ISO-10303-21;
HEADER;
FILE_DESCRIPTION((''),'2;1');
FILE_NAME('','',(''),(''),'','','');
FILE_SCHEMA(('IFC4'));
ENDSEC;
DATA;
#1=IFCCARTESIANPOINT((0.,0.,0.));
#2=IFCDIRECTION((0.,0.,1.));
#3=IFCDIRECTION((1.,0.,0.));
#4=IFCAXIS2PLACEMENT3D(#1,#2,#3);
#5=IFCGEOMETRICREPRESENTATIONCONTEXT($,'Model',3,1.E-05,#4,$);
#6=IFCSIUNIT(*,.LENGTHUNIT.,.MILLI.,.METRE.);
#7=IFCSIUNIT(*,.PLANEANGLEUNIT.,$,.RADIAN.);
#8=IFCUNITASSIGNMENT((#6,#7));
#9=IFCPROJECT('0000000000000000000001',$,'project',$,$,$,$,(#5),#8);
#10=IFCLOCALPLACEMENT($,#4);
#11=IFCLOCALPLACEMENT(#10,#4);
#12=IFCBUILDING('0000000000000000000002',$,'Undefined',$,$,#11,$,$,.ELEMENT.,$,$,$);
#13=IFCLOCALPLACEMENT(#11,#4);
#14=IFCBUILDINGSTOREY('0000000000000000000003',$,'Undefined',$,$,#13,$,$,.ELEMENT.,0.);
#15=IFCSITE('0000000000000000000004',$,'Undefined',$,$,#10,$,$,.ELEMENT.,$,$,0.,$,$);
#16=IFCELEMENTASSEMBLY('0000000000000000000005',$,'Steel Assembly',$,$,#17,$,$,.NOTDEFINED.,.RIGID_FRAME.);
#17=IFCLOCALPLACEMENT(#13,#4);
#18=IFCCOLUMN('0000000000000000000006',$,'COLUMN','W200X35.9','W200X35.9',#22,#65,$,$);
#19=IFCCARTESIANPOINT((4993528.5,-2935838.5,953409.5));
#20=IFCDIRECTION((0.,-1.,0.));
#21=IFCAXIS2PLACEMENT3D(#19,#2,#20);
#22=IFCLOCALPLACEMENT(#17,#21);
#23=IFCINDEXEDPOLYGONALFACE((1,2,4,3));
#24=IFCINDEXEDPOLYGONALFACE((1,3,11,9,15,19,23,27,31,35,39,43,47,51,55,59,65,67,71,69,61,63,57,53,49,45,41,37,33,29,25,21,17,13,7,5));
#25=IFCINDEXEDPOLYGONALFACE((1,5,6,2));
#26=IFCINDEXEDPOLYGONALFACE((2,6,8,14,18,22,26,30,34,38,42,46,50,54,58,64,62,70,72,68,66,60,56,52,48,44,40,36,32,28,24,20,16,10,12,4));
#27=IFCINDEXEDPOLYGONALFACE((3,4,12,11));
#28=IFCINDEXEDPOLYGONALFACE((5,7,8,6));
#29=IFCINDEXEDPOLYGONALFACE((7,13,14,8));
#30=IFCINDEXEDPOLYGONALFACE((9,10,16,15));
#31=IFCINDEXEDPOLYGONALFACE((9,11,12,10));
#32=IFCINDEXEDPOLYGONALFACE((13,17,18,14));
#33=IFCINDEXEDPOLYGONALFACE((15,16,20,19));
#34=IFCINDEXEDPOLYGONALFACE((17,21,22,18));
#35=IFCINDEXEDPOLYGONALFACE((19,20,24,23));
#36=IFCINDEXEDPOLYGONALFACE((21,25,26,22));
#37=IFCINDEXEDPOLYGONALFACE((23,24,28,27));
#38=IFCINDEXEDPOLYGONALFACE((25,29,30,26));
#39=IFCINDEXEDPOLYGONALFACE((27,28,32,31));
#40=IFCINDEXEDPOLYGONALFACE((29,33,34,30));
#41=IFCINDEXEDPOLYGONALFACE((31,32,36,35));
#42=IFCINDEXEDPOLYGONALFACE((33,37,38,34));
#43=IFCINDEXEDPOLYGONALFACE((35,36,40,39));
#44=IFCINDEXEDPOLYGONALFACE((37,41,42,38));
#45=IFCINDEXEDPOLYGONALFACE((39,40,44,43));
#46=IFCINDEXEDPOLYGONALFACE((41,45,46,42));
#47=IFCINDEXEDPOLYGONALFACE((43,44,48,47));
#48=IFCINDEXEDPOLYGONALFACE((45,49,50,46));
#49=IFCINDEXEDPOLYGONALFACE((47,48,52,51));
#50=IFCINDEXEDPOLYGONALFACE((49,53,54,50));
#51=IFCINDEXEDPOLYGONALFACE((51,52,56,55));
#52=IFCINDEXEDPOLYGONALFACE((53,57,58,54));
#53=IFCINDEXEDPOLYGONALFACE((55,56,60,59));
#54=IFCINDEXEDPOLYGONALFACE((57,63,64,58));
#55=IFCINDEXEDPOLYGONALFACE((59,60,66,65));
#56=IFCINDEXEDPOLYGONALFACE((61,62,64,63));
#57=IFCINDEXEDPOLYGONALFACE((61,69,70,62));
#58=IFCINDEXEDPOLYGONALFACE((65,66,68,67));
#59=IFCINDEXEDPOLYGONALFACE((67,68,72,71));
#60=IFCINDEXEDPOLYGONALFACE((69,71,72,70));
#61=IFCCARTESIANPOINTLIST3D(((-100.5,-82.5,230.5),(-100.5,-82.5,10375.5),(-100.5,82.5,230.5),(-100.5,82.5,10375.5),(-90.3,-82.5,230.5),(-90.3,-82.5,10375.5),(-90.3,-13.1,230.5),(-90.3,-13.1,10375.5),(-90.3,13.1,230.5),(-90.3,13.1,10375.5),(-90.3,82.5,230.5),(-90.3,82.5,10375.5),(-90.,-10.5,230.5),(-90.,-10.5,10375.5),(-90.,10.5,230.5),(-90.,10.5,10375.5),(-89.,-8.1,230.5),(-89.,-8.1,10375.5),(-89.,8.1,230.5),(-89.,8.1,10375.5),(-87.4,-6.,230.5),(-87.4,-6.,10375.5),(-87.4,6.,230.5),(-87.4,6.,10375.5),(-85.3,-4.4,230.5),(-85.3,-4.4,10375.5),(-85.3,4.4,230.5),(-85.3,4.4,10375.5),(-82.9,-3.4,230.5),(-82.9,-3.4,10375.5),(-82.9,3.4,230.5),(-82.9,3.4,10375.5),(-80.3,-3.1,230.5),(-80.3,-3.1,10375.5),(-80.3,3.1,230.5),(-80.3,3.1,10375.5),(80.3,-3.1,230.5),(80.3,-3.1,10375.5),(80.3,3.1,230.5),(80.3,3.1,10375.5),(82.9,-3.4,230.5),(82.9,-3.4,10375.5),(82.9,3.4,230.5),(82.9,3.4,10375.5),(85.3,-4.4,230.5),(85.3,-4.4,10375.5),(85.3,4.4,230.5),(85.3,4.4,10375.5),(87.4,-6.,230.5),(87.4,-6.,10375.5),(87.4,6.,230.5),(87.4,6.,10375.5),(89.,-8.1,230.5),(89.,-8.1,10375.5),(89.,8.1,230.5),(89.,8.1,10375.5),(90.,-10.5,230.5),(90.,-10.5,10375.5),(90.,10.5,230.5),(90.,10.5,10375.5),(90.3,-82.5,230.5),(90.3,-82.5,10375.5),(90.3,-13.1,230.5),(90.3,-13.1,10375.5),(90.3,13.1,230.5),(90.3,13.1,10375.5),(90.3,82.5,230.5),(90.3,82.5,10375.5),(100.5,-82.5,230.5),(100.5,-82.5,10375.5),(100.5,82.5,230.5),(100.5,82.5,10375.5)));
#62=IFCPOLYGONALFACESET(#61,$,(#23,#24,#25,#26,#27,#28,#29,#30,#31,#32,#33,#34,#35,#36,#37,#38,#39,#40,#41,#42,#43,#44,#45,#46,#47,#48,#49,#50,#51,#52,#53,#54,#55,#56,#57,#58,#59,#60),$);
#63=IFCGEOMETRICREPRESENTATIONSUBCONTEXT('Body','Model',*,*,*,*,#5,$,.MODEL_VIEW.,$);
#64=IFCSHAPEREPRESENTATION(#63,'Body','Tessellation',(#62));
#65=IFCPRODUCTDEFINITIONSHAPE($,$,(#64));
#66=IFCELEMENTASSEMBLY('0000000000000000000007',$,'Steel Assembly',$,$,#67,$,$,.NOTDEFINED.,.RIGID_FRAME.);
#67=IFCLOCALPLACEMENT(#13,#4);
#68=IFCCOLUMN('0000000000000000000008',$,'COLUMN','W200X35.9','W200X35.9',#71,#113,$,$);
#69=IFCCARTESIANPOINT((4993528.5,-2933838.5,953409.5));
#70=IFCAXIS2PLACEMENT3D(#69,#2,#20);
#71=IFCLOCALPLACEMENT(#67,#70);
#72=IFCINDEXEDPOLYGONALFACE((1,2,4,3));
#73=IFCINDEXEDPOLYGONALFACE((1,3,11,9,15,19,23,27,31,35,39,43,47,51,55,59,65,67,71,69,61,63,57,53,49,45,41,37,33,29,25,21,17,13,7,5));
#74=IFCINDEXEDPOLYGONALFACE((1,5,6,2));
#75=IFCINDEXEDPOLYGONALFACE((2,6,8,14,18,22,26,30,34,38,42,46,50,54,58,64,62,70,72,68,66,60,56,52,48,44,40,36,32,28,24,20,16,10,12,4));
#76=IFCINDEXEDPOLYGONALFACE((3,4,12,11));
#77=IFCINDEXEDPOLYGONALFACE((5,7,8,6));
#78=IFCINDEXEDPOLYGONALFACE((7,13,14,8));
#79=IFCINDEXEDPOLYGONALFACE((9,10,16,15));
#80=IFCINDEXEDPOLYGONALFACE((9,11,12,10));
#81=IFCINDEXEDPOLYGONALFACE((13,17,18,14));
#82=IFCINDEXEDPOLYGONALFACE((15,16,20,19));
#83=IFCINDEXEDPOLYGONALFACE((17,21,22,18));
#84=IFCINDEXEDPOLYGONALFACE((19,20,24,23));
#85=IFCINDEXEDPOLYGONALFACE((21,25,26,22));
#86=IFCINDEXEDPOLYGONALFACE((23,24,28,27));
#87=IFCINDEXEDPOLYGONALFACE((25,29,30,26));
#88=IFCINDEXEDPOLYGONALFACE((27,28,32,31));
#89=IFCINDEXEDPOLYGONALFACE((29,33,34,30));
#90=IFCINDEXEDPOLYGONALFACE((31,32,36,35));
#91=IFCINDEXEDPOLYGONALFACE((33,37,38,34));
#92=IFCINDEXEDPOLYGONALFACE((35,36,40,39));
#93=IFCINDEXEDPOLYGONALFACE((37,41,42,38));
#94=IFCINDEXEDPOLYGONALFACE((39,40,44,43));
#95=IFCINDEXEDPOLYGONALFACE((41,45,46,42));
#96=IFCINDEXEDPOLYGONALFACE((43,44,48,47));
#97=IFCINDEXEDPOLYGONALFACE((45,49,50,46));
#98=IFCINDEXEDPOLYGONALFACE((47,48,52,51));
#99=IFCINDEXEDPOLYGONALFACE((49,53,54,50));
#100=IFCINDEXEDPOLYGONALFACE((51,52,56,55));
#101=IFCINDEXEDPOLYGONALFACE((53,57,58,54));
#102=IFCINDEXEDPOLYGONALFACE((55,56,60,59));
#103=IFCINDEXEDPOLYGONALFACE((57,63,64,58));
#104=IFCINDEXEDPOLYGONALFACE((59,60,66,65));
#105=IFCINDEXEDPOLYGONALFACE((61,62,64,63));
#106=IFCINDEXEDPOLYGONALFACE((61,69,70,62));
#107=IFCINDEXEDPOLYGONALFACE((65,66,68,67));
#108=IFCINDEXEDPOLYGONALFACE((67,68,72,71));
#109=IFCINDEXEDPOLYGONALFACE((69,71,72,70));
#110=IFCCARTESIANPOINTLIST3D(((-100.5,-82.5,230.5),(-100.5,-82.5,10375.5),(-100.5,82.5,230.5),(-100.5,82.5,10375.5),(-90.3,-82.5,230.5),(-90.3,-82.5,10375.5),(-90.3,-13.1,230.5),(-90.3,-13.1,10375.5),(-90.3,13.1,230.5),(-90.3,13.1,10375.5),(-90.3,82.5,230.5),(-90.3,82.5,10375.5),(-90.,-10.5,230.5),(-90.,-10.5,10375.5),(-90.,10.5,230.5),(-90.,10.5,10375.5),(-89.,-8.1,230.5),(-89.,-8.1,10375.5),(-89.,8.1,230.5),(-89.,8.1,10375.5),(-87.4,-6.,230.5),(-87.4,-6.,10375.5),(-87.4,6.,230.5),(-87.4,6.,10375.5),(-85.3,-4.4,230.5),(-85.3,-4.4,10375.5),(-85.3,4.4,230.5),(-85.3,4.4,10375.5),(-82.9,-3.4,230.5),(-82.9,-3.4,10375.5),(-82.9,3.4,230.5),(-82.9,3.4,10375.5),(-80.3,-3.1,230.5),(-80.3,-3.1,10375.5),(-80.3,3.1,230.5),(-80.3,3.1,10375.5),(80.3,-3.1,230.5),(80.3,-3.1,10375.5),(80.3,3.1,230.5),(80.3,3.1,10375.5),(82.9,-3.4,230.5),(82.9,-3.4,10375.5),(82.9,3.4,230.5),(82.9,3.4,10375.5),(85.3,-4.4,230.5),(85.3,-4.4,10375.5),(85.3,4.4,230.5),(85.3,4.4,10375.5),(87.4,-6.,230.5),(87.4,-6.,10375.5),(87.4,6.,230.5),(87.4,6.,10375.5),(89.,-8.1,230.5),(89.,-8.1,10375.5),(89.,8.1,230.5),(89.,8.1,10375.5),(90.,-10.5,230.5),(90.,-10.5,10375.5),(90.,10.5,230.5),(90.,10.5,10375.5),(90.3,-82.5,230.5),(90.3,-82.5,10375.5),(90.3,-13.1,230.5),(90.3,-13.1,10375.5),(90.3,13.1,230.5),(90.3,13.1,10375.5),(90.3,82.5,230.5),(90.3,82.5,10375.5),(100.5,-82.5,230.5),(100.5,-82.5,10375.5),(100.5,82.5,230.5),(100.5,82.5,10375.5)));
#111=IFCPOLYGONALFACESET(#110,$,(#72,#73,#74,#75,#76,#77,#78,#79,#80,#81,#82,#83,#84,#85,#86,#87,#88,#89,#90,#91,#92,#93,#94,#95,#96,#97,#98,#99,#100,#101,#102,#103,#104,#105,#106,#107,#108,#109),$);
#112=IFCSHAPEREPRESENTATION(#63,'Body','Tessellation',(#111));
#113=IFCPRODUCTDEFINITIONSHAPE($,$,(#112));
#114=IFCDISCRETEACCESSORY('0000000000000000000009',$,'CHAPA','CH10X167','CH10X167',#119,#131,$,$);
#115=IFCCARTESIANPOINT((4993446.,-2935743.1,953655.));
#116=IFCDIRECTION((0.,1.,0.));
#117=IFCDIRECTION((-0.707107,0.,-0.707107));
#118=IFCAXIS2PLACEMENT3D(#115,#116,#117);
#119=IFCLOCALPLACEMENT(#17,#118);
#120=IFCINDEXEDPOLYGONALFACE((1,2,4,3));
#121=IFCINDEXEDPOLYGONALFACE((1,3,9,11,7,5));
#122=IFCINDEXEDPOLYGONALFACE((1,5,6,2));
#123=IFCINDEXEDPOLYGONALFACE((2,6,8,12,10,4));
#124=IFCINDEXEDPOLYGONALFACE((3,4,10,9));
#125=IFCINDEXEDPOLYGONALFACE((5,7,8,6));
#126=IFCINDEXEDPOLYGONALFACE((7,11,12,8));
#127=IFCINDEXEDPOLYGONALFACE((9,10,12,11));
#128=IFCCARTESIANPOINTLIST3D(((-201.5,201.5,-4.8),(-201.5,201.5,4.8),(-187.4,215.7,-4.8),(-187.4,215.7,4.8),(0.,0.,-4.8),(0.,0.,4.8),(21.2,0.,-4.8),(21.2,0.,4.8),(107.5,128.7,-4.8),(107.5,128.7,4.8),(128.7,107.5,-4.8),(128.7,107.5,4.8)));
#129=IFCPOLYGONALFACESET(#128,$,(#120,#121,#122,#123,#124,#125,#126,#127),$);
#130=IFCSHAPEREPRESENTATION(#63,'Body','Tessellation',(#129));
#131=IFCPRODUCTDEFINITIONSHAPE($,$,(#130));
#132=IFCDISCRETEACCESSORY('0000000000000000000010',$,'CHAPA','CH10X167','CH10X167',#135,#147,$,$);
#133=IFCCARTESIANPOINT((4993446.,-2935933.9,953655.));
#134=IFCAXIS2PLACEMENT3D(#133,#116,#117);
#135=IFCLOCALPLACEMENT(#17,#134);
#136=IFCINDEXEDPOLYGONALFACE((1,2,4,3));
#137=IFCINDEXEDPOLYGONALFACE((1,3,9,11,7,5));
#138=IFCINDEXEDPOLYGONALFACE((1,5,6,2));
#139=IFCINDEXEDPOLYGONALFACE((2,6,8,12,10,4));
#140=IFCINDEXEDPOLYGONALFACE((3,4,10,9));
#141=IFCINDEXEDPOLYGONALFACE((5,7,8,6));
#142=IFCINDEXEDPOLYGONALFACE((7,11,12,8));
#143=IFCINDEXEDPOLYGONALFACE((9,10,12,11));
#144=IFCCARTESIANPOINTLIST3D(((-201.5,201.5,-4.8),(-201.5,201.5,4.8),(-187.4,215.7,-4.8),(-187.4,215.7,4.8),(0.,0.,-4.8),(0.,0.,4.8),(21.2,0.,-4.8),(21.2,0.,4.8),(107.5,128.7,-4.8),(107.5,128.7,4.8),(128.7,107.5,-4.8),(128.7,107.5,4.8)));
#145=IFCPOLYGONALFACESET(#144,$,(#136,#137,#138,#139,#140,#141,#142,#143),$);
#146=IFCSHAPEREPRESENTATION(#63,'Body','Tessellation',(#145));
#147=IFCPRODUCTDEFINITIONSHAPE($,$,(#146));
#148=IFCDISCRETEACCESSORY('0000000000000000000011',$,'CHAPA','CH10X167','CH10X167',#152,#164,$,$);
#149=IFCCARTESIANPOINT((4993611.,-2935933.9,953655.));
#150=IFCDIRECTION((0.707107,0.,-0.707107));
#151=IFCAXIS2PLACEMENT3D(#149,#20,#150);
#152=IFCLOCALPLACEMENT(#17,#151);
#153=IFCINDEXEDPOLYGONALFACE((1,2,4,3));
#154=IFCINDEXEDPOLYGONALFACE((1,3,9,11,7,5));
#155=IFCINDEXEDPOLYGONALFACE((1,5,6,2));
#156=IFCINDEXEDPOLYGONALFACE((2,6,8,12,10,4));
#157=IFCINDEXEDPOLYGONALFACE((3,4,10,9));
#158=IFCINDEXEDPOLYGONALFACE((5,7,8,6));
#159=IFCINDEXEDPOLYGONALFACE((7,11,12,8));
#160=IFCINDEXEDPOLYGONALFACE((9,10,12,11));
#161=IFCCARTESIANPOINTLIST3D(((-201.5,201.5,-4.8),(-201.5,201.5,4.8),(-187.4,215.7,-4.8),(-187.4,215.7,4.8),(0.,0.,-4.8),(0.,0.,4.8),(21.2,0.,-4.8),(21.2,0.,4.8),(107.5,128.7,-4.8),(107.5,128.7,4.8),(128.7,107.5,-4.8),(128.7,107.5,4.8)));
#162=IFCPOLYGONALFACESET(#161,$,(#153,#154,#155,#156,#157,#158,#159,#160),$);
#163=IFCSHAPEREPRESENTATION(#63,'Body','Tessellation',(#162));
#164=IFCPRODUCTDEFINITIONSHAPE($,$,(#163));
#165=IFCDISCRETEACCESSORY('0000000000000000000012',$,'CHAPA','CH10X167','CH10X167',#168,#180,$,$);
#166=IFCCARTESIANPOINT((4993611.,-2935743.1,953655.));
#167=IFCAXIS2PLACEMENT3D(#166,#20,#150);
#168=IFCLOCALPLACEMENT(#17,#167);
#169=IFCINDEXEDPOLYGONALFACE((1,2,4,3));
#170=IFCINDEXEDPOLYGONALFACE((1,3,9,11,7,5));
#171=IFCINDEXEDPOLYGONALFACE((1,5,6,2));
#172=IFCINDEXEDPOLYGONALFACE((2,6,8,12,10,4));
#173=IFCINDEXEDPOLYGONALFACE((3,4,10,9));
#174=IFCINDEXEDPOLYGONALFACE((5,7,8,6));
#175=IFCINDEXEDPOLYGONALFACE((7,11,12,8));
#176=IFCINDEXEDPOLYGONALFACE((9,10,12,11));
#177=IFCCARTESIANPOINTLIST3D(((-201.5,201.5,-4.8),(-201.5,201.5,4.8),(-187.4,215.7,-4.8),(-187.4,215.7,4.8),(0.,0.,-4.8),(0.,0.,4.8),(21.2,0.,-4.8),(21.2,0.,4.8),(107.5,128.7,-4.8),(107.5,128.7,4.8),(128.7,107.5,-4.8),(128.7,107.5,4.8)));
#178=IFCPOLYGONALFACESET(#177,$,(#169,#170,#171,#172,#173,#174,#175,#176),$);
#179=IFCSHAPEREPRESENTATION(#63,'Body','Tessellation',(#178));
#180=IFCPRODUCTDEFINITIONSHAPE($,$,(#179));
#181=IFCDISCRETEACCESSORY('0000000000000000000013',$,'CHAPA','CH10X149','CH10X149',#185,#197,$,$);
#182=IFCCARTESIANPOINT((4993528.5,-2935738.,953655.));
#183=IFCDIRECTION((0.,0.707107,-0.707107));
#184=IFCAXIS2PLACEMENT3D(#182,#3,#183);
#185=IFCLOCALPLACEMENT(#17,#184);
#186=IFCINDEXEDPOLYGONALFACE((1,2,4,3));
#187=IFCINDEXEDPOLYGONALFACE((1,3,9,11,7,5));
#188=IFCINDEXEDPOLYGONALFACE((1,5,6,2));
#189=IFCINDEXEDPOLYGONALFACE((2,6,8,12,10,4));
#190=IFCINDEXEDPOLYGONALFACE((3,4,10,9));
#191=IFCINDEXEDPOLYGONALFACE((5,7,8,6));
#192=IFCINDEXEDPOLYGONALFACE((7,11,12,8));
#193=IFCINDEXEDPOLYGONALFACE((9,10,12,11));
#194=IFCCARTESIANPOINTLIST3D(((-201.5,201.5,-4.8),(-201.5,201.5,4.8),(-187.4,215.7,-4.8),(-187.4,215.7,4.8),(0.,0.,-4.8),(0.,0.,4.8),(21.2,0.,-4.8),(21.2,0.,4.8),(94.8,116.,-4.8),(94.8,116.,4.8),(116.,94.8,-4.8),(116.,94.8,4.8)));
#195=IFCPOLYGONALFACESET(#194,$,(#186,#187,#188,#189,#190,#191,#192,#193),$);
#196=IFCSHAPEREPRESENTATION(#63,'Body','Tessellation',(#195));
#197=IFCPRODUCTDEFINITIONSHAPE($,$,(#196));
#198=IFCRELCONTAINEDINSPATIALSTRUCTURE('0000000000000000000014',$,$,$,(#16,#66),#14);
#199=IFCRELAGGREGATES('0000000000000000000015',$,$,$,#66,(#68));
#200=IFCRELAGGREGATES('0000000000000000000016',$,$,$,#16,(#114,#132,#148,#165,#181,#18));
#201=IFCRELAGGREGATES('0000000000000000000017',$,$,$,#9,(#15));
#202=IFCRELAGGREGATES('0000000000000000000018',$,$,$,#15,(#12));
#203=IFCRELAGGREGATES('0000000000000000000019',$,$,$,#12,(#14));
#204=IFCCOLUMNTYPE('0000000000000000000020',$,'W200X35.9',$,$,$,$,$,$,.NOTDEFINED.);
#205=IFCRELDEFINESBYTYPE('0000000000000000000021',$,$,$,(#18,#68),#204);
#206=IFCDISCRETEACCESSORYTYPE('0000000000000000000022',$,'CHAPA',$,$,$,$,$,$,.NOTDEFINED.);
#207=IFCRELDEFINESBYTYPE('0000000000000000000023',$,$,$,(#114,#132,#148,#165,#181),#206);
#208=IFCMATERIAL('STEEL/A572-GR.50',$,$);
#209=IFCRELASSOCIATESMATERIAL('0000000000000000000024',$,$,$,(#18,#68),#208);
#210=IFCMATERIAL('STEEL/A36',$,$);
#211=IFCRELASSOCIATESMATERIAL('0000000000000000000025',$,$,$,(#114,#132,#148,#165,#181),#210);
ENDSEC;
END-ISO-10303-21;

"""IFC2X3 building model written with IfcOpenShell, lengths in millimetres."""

from ifc_helpers import new_model, si_unit, frame, origin_with_axes, origin_2d_with_axis, place, context, subcontext, project, spatial, polyline, i_section, outline, extrude, clip, halfspace, material, type_object, element, aggregate, save


model = new_model("IFC2X3")

# Units and contexts
model_context = context("Model", 3, precision=1e-05, world=origin_with_axes())
body_context = subcontext(model_context, "Body", "Model", "MODEL_VIEW")
ifc_project = project(units=[si_unit("LENGTHUNIT", "METRE", prefix="MILLI"), si_unit("PLANEANGLEUNIT", "RADIAN")], contexts=[model_context])

# Site, building, storey
site_placement = place(None, origin_with_axes())
site = spatial("IfcSite", under=ifc_project, at=site_placement, Name="Undefined", CompositionType="ELEMENT", RefElevation=0.0)
building_placement = place(site_placement, origin_with_axes())
building = spatial("IfcBuilding", under=site, at=building_placement, Name="Undefined", CompositionType="ELEMENT")
storey_placement = place(building_placement, origin_with_axes())
storey = spatial("IfcBuildingStorey", under=building, at=storey_placement, Name="Undefined", CompositionType="ELEMENT", Elevation=0.0)

# Element assemblies, columns
assembly_1_placement = place(storey_placement, origin_with_axes())
assembly_1 = element("IfcElementAssembly", 1, at=assembly_1_placement, inside=storey, Name="Steel Assembly", AssemblyPlace="NOTDEFINED", PredefinedType="RIGID_FRAME")
ifc_material_1 = material(Name="STEEL/A572-GR.50")
column_type = type_object("IfcColumnType", Name="W200X35.9", PredefinedType="NOTDEFINED")
column_1_placement = place(assembly_1_placement, frame((4993528.5, -2935838.5, 953409.5), z_axis=(0.0, 0.0, 1.0), x_axis=(0.0, -1.0, 0.0)))
column_1 = element("IfcColumn", 2, at=column_1_placement, type_object=column_type, material=ifc_material_1, Name="COLUMN", Description="W200X35.9", ObjectType="W200X35.9", context=body_context, shape_type="Clipping", body=[
    clip(clip(clip(extrude(i_section(OverallWidth=165.0, OverallDepth=201.0, WebThickness=6.2, FlangeThickness=10.2, FilletRadius=10.0, at=origin_2d_with_axis()), frame((0.0, 0.0, 10606.0), z_axis=(0.0, 0.0, -1.0), x_axis=(0.0, 1.0, 0.0)), (0.0, 0.0, 1.0), 10375.5), halfspace(frame((-100.5, -82.5, 230.5), z_axis=(0.0, 0.0, -1.0), x_axis=(1.0, 0.0, 0.0)), False)), halfspace(frame((-100.5, 82.5, 10375.5), z_axis=(0.0, 0.0, 1.0), x_axis=(1.0, 0.0, 0.0)), False)), halfspace(frame((-100.5, 0.0, 230.5), z_axis=(0.0, 0.0, 1.0), x_axis=(0.0, 1.0, 0.0)), True)),
])
assembly_2_placement = place(storey_placement, origin_with_axes())
assembly_2 = element("IfcElementAssembly", 3, at=assembly_2_placement, inside=storey, Name="Steel Assembly", AssemblyPlace="NOTDEFINED", PredefinedType="RIGID_FRAME")
column_2_placement = place(assembly_2_placement, frame((4993528.5, -2933838.5, 953409.5), z_axis=(0.0, 0.0, 1.0), x_axis=(0.0, -1.0, 0.0)))
column_2 = element("IfcColumn", 4, at=column_2_placement, type_object=column_type, material=ifc_material_1, Name="COLUMN", Description="W200X35.9", ObjectType="W200X35.9", context=body_context, shape_type="Clipping", body=[
    clip(clip(clip(extrude(i_section(OverallWidth=165.0, OverallDepth=201.0, WebThickness=6.2, FlangeThickness=10.2, FilletRadius=10.0, at=origin_2d_with_axis()), frame((0.0, 0.0, 10606.0), z_axis=(0.0, 0.0, -1.0), x_axis=(0.0, 1.0, 0.0)), (0.0, 0.0, 1.0), 10375.5), halfspace(frame((-100.5, -82.5, 230.5), z_axis=(0.0, 0.0, -1.0), x_axis=(1.0, 0.0, 0.0)), False)), halfspace(frame((-100.5, 82.5, 10375.5), z_axis=(0.0, 0.0, 1.0), x_axis=(1.0, 0.0, 0.0)), False)), halfspace(frame((-100.5, 0.0, 230.5), z_axis=(0.0, 0.0, 1.0), x_axis=(0.0, 1.0, 0.0)), True)),
])

# Discrete accessories
ifc_material_2 = material(Name="STEEL/A36")
discrete_accessory_type_1 = type_object("IfcDiscreteAccessoryType", Name="CHAPA")
discrete_accessory_1_placement = place(assembly_1_placement, frame((4993446.0, -2935743.1, 953655.0), z_axis=(0.0, 1.0, 0.0), x_axis=(-0.707107, 0.0, -0.707107)))
discrete_accessory_1 = element("IfcDiscreteAccessory", 5, at=discrete_accessory_1_placement, type_object=discrete_accessory_type_1, material=ifc_material_2, Name="CHAPA", Description="CH10X167", ObjectType="CH10X167", context=body_context, shape_type="SweptSolid", body=[
    extrude(outline(polyline([(0.0, 0.0), (21.2, 0.0), (128.7, 107.5), (107.5, 128.7), (-187.4, 215.7), (-201.5, 201.5), (0.0, 0.0)])), frame((0.0, 0.0, -4.8), z_axis=(0.0, 0.0, 1.0), x_axis=(1.0, 0.0, 0.0)), (0.0, 0.0, 1.0), 9.5),
])
discrete_accessory_2_placement = place(assembly_1_placement, frame((4993446.0, -2935933.9, 953655.0), z_axis=(0.0, 1.0, 0.0), x_axis=(-0.707107, 0.0, -0.707107)))
discrete_accessory_2 = element("IfcDiscreteAccessory", 6, at=discrete_accessory_2_placement, type_object=discrete_accessory_type_1, material=ifc_material_2, Name="CHAPA", Description="CH10X167", ObjectType="CH10X167", context=body_context, shape_type="SweptSolid", body=[
    extrude(outline(polyline([(0.0, 0.0), (21.2, 0.0), (128.7, 107.5), (107.5, 128.7), (-187.4, 215.7), (-201.5, 201.5), (0.0, 0.0)])), frame((0.0, 0.0, -4.8), z_axis=(0.0, 0.0, 1.0), x_axis=(1.0, 0.0, 0.0)), (0.0, 0.0, 1.0), 9.5),
])
discrete_accessory_3_placement = place(assembly_1_placement, frame((4993611.0, -2935933.9, 953655.0), z_axis=(0.0, -1.0, 0.0), x_axis=(0.707107, 0.0, -0.707107)))
discrete_accessory_3 = element("IfcDiscreteAccessory", 7, at=discrete_accessory_3_placement, type_object=discrete_accessory_type_1, material=ifc_material_2, Name="CHAPA", Description="CH10X167", ObjectType="CH10X167", context=body_context, shape_type="SweptSolid", body=[
    extrude(outline(polyline([(0.0, 0.0), (21.2, 0.0), (128.7, 107.5), (107.5, 128.7), (-187.4, 215.7), (-201.5, 201.5), (0.0, 0.0)])), frame((0.0, 0.0, -4.8), z_axis=(0.0, 0.0, 1.0), x_axis=(1.0, 0.0, 0.0)), (0.0, 0.0, 1.0), 9.5),
])
discrete_accessory_4_placement = place(assembly_1_placement, frame((4993611.0, -2935743.1, 953655.0), z_axis=(0.0, -1.0, 0.0), x_axis=(0.707107, 0.0, -0.707107)))
discrete_accessory_4 = element("IfcDiscreteAccessory", 8, at=discrete_accessory_4_placement, type_object=discrete_accessory_type_1, material=ifc_material_2, Name="CHAPA", Description="CH10X167", ObjectType="CH10X167", context=body_context, shape_type="SweptSolid", body=[
    extrude(outline(polyline([(0.0, 0.0), (21.2, 0.0), (128.7, 107.5), (107.5, 128.7), (-187.4, 215.7), (-201.5, 201.5), (0.0, 0.0)])), frame((0.0, 0.0, -4.8), z_axis=(0.0, 0.0, 1.0), x_axis=(1.0, 0.0, 0.0)), (0.0, 0.0, 1.0), 9.5),
])
discrete_accessory_5_placement = place(assembly_1_placement, frame((4993528.5, -2935738.0, 953655.0), z_axis=(1.0, 0.0, 0.0), x_axis=(0.0, 0.707107, -0.707107)))
discrete_accessory_5 = element("IfcDiscreteAccessory", 9, at=discrete_accessory_5_placement, type_object=discrete_accessory_type_1, material=ifc_material_2, Name="CHAPA", Description="CH10X149", ObjectType="CH10X149", context=body_context, shape_type="SweptSolid", body=[
    extrude(outline(polyline([(0.0, 0.0), (21.2, 0.0), (116.0, 94.8), (94.8, 116.0), (-187.4, 215.7), (-201.5, 201.5), (0.0, 0.0)])), frame((0.0, 0.0, -4.8), z_axis=(0.0, 0.0, 1.0), x_axis=(1.0, 0.0, 0.0)), (0.0, 0.0, 1.0), 9.5),
])
aggregate(assembly_2, [column_2])

aggregate(assembly_1, [discrete_accessory_1, discrete_accessory_2, discrete_accessory_3, discrete_accessory_4, discrete_accessory_5, column_1])

save(model, "model.ifc")
